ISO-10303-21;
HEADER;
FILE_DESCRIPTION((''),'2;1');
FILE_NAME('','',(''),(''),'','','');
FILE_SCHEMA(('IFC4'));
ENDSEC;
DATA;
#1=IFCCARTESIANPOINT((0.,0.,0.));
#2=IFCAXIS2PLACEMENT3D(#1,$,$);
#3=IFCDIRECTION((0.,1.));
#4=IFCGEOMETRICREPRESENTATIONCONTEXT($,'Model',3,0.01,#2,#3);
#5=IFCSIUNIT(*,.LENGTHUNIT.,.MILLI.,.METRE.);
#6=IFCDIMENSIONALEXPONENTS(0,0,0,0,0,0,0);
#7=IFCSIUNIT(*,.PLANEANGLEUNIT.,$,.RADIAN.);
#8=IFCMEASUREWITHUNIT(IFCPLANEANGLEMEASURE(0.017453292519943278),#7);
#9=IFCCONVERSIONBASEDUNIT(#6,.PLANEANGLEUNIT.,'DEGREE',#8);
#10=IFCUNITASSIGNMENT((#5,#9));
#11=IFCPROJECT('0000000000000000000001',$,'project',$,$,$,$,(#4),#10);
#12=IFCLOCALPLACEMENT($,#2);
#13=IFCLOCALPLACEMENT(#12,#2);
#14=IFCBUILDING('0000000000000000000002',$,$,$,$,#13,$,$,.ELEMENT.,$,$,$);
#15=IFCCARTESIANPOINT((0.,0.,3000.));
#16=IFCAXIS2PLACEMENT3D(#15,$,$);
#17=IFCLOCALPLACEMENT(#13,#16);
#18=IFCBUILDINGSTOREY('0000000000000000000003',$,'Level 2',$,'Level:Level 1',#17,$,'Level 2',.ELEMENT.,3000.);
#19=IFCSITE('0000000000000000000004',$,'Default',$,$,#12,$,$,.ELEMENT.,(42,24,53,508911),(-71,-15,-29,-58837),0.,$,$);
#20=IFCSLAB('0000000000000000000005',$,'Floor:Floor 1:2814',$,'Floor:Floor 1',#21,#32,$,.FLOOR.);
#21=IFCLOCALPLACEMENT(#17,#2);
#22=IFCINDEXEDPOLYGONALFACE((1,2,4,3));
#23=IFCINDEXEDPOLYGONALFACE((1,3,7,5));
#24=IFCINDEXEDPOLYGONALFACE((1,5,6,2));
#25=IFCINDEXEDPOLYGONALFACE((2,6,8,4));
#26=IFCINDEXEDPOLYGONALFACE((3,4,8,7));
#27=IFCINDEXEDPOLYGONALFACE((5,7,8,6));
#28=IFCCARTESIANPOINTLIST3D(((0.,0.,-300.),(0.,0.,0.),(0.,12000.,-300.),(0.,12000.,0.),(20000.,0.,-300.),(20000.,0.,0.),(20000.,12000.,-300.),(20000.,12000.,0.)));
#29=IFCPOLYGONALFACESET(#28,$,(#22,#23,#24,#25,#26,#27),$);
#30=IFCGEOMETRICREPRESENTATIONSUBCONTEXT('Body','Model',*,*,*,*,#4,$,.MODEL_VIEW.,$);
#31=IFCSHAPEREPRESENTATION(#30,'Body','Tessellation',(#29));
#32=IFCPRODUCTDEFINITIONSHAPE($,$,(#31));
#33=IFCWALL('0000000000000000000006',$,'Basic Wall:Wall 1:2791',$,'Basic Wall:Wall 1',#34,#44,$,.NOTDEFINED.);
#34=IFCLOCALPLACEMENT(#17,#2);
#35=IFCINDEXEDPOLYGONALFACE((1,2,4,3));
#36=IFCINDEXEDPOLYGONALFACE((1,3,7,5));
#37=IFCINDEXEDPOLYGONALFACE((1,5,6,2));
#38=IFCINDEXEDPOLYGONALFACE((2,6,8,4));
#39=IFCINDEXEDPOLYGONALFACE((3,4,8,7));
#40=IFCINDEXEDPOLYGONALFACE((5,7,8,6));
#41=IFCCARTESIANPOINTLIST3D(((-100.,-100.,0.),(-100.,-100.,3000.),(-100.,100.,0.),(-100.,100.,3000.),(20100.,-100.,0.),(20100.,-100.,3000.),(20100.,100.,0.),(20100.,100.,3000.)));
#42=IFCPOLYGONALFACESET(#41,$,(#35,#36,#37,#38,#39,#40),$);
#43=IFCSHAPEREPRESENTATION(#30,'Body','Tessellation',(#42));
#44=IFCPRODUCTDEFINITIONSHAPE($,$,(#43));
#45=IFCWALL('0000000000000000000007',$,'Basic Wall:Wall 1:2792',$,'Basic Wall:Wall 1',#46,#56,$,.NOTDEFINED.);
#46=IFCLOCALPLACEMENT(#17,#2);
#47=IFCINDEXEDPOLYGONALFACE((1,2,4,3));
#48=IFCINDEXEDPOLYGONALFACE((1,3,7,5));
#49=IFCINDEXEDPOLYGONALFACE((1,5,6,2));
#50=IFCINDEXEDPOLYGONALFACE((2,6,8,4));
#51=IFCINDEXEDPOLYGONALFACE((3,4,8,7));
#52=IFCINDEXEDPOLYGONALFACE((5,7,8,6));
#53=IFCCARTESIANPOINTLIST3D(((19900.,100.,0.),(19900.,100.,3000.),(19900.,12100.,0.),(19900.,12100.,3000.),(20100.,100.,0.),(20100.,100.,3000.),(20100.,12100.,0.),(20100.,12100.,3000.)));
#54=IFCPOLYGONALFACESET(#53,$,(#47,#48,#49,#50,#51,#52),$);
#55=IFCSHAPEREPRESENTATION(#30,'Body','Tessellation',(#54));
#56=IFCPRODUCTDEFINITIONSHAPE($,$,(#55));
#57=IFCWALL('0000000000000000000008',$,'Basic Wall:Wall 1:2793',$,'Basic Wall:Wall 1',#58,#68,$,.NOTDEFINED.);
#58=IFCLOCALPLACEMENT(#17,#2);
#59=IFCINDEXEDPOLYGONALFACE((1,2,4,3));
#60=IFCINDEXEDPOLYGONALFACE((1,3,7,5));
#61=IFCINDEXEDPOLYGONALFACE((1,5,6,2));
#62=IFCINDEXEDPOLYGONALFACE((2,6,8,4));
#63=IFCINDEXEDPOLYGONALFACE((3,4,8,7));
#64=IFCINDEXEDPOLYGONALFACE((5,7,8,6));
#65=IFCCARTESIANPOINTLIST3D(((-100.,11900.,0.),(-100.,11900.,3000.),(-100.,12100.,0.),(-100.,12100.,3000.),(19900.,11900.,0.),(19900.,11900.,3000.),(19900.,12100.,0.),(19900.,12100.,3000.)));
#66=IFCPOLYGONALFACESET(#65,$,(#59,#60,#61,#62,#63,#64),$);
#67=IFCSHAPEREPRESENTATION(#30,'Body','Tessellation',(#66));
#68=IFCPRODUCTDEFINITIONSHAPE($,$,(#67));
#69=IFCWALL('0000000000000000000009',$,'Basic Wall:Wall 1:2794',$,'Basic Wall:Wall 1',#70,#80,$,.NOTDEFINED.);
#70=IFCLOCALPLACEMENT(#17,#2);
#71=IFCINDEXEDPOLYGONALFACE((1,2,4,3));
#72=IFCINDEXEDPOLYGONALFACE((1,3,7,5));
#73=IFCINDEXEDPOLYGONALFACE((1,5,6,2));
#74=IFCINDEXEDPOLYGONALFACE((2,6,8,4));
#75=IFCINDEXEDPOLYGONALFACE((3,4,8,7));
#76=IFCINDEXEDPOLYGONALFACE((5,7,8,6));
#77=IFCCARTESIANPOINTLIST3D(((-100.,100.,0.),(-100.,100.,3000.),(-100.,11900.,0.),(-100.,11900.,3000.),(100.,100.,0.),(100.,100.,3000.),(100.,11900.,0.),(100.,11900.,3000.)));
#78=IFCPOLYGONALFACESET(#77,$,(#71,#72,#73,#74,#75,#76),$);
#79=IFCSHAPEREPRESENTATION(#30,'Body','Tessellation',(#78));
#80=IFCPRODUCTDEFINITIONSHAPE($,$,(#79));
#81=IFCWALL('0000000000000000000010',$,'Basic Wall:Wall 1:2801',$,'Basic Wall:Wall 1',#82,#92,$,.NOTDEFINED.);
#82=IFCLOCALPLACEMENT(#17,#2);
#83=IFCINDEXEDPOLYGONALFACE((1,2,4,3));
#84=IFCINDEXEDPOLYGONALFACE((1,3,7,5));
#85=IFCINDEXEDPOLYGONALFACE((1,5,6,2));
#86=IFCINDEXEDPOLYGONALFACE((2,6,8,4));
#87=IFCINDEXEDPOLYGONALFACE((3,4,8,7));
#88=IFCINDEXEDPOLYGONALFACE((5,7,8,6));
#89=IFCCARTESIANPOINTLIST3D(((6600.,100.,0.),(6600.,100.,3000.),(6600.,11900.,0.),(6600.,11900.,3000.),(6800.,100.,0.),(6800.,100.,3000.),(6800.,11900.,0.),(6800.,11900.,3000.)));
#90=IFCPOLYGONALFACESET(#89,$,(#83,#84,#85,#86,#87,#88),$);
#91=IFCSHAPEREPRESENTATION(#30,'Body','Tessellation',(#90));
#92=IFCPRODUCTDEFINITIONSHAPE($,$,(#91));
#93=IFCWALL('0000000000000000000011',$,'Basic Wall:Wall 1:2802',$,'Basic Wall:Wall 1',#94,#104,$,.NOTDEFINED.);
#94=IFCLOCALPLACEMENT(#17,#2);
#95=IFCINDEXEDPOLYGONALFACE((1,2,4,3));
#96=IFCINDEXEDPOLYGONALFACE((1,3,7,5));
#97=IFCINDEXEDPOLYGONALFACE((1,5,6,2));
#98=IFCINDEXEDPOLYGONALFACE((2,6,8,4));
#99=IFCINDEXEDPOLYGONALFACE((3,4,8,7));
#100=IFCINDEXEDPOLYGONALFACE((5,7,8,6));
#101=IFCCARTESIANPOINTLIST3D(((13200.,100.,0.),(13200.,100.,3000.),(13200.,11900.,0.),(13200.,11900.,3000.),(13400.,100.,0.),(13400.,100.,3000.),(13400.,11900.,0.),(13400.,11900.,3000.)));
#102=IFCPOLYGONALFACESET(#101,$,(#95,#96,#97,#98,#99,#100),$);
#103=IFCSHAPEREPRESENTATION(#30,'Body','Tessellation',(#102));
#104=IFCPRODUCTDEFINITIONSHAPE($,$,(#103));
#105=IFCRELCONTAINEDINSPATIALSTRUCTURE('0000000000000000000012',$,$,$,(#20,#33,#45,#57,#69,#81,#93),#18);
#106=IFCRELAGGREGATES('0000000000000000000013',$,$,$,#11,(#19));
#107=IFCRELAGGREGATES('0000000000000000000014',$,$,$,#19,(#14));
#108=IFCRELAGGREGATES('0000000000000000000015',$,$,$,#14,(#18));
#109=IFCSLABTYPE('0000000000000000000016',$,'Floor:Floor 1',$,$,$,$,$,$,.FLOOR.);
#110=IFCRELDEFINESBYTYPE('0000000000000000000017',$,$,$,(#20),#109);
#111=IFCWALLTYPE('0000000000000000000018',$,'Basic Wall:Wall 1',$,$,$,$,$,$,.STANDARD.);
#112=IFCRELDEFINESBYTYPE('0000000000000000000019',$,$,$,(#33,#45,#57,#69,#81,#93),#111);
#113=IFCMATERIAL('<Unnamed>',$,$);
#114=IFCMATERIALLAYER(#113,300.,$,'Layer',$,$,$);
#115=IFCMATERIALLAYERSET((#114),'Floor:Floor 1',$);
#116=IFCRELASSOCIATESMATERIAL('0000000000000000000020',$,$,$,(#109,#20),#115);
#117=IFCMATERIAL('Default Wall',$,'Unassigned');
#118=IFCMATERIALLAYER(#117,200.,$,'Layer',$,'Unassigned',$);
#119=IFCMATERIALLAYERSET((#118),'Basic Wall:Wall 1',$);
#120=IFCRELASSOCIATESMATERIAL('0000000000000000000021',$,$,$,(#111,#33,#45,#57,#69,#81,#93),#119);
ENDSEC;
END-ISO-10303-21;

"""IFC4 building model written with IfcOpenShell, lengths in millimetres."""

from ifc_helpers import new_model, entity, si_unit, converted_unit, direction, frame, frame_2d, origin, origin_2d_with_axis, place, context, subcontext, project, spatial, rectangle, extrude, material, layer, layer_set, layer_usage, type_object, element, save


model = new_model("IFC4")

# Units and contexts
model_context = context("Model", 3, precision=0.01, world=origin(), true_north=direction((0.0, 1.0)))
body_context = subcontext(model_context, "Body", "Model", "MODEL_VIEW")
ifc_project = project(units=[si_unit("LENGTHUNIT", "METRE", prefix="MILLI"), converted_unit("PLANEANGLEUNIT", "DEGREE", entity("IfcPlaneAngleMeasure", 0.017453292519943278), si_unit("PLANEANGLEUNIT", "RADIAN"), dimensions=[0, 0, 0, 0, 0, 0, 0])], contexts=[model_context])

# Site, building, storey
site_placement = place(None, origin())
site = spatial("IfcSite", under=ifc_project, at=site_placement, Name="Default", CompositionType="ELEMENT", RefLatitude=(42, 24, 53, 508911), RefLongitude=(-71, -15, -29, -58837), RefElevation=0.0)
building_placement = place(site_placement, origin())
building = spatial("IfcBuilding", under=site, at=building_placement, CompositionType="ELEMENT")
storey_placement = place(building_placement, frame((0.0, 0.0, 3000.0)))
storey = spatial("IfcBuildingStorey", under=building, at=storey_placement, Name="Level 2", ObjectType="Level:Level 1", LongName="Level 2", CompositionType="ELEMENT", Elevation=3000.0)

# Slab
ifc_material_1 = material(Name="<Unnamed>")
ifc_layer_1 = layer(ifc_material_1, 300.0, Name="Layer")
ifc_layer_set_1 = layer_set([ifc_layer_1], Name="Floor:Floor 1")
ifc_layer_usage_1 = layer_usage(ifc_layer_set_1, "AXIS3", "POSITIVE", 0.0)
slab_type = type_object("IfcSlabType", Name="Floor:Floor 1", PredefinedType="FLOOR", material=ifc_layer_set_1)
slab_placement = place(storey_placement, origin())
element("IfcSlab", 1, at=slab_placement, inside=storey, type_object=slab_type, material=ifc_layer_usage_1, Name="Floor:Floor 1:2814", ObjectType="Floor:Floor 1", PredefinedType="FLOOR", context=body_context, shape_type="SweptSolid", body=[
    extrude(rectangle(XDim=12000.0, YDim=20000.0, at=origin_2d_with_axis()), frame((10000.0, 6000.0, 0.0), z_axis=(0.0, 0.0, -1.0), x_axis=(0.0, 1.0, 0.0)), (0.0, 0.0, 1.0), 300.0),
])

# Walls
ifc_material_2 = material(Name="Default Wall", Category="Unassigned")
ifc_layer_2 = layer(ifc_material_2, 200.0, Name="Layer", Category="Unassigned")
ifc_layer_set_2 = layer_set([ifc_layer_2], Name="Basic Wall:Wall 1")
ifc_layer_usage_2 = layer_usage(ifc_layer_set_2, "AXIS2", "NEGATIVE", 100.0)
wall_type = type_object("IfcWallType", Name="Basic Wall:Wall 1", PredefinedType="STANDARD", material=ifc_layer_set_2)
wall_1_placement = place(storey_placement, frame((-100.0, 0.0, 0.0)))
element("IfcWall", 2, at=wall_1_placement, inside=storey, type_object=wall_type, material=ifc_layer_usage_2, Name="Basic Wall:Wall 1:2791", ObjectType="Basic Wall:Wall 1", PredefinedType="NOTDEFINED", context=body_context, shape_type="SweptSolid", body=[
    extrude(rectangle(XDim=20200.0, YDim=200.0, at=frame_2d((10100.0, 0.0), x_axis=(-1.0, 0.0))), origin(), (0.0, 0.0, 1.0), 3000.0),
])
ifc_layer_usage_3 = layer_usage(ifc_layer_set_2, "AXIS2", "NEGATIVE", 100.0)
wall_2_placement = place(storey_placement, frame((20000.0, 100.0, 0.0), z_axis=(0.0, 0.0, 1.0), x_axis=(0.0, 1.0, 0.0)))
element("IfcWall", 3, at=wall_2_placement, inside=storey, type_object=wall_type, material=ifc_layer_usage_3, Name="Basic Wall:Wall 1:2792", ObjectType="Basic Wall:Wall 1", PredefinedType="NOTDEFINED", context=body_context, shape_type="SweptSolid", body=[
    extrude(rectangle(XDim=12000.0, YDim=200.0, at=frame_2d((6000.0, 0.0), x_axis=(-1.0, 0.0))), origin(), (0.0, 0.0, 1.0), 3000.0),
])
ifc_layer_usage_4 = layer_usage(ifc_layer_set_2, "AXIS2", "NEGATIVE", 100.0)
wall_3_placement = place(storey_placement, frame((19900.0, 12000.0, 0.0), z_axis=(0.0, 0.0, 1.0), x_axis=(-1.0, 0.0, 0.0)))
element("IfcWall", 4, at=wall_3_placement, inside=storey, type_object=wall_type, material=ifc_layer_usage_4, Name="Basic Wall:Wall 1:2793", ObjectType="Basic Wall:Wall 1", PredefinedType="NOTDEFINED", context=body_context, shape_type="SweptSolid", body=[
    extrude(rectangle(XDim=20000.0, YDim=200.0, at=frame_2d((10000.0, 0.0), x_axis=(-1.0, 0.0))), origin(), (0.0, 0.0, 1.0), 3000.0),
])
ifc_layer_usage_5 = layer_usage(ifc_layer_set_2, "AXIS2", "NEGATIVE", 100.0)
wall_4_placement = place(storey_placement, frame((0.0, 11900.0, 0.0), z_axis=(0.0, 0.0, 1.0), x_axis=(0.0, -1.0, 0.0)))
element("IfcWall", 5, at=wall_4_placement, inside=storey, type_object=wall_type, material=ifc_layer_usage_5, Name="Basic Wall:Wall 1:2794", ObjectType="Basic Wall:Wall 1", PredefinedType="NOTDEFINED", context=body_context, shape_type="SweptSolid", body=[
    extrude(rectangle(XDim=11800.0, YDim=200.0, at=frame_2d((5900.0, 0.0), x_axis=(-1.0, 0.0))), origin(), (0.0, 0.0, 1.0), 3000.0),
])
ifc_layer_usage_6 = layer_usage(ifc_layer_set_2, "AXIS2", "NEGATIVE", 100.0)
wall_5_placement = place(storey_placement, frame((6700.0, 100.0, 0.0), z_axis=(0.0, 0.0, 1.0), x_axis=(0.0, 1.0, 0.0)))
element("IfcWall", 6, at=wall_5_placement, inside=storey, type_object=wall_type, material=ifc_layer_usage_6, Name="Basic Wall:Wall 1:2801", ObjectType="Basic Wall:Wall 1", PredefinedType="NOTDEFINED", context=body_context, shape_type="SweptSolid", body=[
    extrude(rectangle(XDim=11800.0, YDim=200.0, at=frame_2d((5900.0, 0.0), x_axis=(-1.0, 0.0))), origin(), (0.0, 0.0, 1.0), 3000.0),
])
ifc_layer_usage_7 = layer_usage(ifc_layer_set_2, "AXIS2", "NEGATIVE", 100.0)
wall_6_placement = place(storey_placement, frame((13300.0, 100.0, 0.0), z_axis=(0.0, 0.0, 1.0), x_axis=(0.0, 1.0, 0.0)))
element("IfcWall", 7, at=wall_6_placement, inside=storey, type_object=wall_type, material=ifc_layer_usage_7, Name="Basic Wall:Wall 1:2802", ObjectType="Basic Wall:Wall 1", PredefinedType="NOTDEFINED", context=body_context, shape_type="SweptSolid", body=[
    extrude(rectangle(XDim=11800.0, YDim=200.0, at=frame_2d((5900.0, 0.0), x_axis=(-1.0, 0.0))), origin(), (0.0, 0.0, 1.0), 3000.0),
])

save(model, "model.ifc")
